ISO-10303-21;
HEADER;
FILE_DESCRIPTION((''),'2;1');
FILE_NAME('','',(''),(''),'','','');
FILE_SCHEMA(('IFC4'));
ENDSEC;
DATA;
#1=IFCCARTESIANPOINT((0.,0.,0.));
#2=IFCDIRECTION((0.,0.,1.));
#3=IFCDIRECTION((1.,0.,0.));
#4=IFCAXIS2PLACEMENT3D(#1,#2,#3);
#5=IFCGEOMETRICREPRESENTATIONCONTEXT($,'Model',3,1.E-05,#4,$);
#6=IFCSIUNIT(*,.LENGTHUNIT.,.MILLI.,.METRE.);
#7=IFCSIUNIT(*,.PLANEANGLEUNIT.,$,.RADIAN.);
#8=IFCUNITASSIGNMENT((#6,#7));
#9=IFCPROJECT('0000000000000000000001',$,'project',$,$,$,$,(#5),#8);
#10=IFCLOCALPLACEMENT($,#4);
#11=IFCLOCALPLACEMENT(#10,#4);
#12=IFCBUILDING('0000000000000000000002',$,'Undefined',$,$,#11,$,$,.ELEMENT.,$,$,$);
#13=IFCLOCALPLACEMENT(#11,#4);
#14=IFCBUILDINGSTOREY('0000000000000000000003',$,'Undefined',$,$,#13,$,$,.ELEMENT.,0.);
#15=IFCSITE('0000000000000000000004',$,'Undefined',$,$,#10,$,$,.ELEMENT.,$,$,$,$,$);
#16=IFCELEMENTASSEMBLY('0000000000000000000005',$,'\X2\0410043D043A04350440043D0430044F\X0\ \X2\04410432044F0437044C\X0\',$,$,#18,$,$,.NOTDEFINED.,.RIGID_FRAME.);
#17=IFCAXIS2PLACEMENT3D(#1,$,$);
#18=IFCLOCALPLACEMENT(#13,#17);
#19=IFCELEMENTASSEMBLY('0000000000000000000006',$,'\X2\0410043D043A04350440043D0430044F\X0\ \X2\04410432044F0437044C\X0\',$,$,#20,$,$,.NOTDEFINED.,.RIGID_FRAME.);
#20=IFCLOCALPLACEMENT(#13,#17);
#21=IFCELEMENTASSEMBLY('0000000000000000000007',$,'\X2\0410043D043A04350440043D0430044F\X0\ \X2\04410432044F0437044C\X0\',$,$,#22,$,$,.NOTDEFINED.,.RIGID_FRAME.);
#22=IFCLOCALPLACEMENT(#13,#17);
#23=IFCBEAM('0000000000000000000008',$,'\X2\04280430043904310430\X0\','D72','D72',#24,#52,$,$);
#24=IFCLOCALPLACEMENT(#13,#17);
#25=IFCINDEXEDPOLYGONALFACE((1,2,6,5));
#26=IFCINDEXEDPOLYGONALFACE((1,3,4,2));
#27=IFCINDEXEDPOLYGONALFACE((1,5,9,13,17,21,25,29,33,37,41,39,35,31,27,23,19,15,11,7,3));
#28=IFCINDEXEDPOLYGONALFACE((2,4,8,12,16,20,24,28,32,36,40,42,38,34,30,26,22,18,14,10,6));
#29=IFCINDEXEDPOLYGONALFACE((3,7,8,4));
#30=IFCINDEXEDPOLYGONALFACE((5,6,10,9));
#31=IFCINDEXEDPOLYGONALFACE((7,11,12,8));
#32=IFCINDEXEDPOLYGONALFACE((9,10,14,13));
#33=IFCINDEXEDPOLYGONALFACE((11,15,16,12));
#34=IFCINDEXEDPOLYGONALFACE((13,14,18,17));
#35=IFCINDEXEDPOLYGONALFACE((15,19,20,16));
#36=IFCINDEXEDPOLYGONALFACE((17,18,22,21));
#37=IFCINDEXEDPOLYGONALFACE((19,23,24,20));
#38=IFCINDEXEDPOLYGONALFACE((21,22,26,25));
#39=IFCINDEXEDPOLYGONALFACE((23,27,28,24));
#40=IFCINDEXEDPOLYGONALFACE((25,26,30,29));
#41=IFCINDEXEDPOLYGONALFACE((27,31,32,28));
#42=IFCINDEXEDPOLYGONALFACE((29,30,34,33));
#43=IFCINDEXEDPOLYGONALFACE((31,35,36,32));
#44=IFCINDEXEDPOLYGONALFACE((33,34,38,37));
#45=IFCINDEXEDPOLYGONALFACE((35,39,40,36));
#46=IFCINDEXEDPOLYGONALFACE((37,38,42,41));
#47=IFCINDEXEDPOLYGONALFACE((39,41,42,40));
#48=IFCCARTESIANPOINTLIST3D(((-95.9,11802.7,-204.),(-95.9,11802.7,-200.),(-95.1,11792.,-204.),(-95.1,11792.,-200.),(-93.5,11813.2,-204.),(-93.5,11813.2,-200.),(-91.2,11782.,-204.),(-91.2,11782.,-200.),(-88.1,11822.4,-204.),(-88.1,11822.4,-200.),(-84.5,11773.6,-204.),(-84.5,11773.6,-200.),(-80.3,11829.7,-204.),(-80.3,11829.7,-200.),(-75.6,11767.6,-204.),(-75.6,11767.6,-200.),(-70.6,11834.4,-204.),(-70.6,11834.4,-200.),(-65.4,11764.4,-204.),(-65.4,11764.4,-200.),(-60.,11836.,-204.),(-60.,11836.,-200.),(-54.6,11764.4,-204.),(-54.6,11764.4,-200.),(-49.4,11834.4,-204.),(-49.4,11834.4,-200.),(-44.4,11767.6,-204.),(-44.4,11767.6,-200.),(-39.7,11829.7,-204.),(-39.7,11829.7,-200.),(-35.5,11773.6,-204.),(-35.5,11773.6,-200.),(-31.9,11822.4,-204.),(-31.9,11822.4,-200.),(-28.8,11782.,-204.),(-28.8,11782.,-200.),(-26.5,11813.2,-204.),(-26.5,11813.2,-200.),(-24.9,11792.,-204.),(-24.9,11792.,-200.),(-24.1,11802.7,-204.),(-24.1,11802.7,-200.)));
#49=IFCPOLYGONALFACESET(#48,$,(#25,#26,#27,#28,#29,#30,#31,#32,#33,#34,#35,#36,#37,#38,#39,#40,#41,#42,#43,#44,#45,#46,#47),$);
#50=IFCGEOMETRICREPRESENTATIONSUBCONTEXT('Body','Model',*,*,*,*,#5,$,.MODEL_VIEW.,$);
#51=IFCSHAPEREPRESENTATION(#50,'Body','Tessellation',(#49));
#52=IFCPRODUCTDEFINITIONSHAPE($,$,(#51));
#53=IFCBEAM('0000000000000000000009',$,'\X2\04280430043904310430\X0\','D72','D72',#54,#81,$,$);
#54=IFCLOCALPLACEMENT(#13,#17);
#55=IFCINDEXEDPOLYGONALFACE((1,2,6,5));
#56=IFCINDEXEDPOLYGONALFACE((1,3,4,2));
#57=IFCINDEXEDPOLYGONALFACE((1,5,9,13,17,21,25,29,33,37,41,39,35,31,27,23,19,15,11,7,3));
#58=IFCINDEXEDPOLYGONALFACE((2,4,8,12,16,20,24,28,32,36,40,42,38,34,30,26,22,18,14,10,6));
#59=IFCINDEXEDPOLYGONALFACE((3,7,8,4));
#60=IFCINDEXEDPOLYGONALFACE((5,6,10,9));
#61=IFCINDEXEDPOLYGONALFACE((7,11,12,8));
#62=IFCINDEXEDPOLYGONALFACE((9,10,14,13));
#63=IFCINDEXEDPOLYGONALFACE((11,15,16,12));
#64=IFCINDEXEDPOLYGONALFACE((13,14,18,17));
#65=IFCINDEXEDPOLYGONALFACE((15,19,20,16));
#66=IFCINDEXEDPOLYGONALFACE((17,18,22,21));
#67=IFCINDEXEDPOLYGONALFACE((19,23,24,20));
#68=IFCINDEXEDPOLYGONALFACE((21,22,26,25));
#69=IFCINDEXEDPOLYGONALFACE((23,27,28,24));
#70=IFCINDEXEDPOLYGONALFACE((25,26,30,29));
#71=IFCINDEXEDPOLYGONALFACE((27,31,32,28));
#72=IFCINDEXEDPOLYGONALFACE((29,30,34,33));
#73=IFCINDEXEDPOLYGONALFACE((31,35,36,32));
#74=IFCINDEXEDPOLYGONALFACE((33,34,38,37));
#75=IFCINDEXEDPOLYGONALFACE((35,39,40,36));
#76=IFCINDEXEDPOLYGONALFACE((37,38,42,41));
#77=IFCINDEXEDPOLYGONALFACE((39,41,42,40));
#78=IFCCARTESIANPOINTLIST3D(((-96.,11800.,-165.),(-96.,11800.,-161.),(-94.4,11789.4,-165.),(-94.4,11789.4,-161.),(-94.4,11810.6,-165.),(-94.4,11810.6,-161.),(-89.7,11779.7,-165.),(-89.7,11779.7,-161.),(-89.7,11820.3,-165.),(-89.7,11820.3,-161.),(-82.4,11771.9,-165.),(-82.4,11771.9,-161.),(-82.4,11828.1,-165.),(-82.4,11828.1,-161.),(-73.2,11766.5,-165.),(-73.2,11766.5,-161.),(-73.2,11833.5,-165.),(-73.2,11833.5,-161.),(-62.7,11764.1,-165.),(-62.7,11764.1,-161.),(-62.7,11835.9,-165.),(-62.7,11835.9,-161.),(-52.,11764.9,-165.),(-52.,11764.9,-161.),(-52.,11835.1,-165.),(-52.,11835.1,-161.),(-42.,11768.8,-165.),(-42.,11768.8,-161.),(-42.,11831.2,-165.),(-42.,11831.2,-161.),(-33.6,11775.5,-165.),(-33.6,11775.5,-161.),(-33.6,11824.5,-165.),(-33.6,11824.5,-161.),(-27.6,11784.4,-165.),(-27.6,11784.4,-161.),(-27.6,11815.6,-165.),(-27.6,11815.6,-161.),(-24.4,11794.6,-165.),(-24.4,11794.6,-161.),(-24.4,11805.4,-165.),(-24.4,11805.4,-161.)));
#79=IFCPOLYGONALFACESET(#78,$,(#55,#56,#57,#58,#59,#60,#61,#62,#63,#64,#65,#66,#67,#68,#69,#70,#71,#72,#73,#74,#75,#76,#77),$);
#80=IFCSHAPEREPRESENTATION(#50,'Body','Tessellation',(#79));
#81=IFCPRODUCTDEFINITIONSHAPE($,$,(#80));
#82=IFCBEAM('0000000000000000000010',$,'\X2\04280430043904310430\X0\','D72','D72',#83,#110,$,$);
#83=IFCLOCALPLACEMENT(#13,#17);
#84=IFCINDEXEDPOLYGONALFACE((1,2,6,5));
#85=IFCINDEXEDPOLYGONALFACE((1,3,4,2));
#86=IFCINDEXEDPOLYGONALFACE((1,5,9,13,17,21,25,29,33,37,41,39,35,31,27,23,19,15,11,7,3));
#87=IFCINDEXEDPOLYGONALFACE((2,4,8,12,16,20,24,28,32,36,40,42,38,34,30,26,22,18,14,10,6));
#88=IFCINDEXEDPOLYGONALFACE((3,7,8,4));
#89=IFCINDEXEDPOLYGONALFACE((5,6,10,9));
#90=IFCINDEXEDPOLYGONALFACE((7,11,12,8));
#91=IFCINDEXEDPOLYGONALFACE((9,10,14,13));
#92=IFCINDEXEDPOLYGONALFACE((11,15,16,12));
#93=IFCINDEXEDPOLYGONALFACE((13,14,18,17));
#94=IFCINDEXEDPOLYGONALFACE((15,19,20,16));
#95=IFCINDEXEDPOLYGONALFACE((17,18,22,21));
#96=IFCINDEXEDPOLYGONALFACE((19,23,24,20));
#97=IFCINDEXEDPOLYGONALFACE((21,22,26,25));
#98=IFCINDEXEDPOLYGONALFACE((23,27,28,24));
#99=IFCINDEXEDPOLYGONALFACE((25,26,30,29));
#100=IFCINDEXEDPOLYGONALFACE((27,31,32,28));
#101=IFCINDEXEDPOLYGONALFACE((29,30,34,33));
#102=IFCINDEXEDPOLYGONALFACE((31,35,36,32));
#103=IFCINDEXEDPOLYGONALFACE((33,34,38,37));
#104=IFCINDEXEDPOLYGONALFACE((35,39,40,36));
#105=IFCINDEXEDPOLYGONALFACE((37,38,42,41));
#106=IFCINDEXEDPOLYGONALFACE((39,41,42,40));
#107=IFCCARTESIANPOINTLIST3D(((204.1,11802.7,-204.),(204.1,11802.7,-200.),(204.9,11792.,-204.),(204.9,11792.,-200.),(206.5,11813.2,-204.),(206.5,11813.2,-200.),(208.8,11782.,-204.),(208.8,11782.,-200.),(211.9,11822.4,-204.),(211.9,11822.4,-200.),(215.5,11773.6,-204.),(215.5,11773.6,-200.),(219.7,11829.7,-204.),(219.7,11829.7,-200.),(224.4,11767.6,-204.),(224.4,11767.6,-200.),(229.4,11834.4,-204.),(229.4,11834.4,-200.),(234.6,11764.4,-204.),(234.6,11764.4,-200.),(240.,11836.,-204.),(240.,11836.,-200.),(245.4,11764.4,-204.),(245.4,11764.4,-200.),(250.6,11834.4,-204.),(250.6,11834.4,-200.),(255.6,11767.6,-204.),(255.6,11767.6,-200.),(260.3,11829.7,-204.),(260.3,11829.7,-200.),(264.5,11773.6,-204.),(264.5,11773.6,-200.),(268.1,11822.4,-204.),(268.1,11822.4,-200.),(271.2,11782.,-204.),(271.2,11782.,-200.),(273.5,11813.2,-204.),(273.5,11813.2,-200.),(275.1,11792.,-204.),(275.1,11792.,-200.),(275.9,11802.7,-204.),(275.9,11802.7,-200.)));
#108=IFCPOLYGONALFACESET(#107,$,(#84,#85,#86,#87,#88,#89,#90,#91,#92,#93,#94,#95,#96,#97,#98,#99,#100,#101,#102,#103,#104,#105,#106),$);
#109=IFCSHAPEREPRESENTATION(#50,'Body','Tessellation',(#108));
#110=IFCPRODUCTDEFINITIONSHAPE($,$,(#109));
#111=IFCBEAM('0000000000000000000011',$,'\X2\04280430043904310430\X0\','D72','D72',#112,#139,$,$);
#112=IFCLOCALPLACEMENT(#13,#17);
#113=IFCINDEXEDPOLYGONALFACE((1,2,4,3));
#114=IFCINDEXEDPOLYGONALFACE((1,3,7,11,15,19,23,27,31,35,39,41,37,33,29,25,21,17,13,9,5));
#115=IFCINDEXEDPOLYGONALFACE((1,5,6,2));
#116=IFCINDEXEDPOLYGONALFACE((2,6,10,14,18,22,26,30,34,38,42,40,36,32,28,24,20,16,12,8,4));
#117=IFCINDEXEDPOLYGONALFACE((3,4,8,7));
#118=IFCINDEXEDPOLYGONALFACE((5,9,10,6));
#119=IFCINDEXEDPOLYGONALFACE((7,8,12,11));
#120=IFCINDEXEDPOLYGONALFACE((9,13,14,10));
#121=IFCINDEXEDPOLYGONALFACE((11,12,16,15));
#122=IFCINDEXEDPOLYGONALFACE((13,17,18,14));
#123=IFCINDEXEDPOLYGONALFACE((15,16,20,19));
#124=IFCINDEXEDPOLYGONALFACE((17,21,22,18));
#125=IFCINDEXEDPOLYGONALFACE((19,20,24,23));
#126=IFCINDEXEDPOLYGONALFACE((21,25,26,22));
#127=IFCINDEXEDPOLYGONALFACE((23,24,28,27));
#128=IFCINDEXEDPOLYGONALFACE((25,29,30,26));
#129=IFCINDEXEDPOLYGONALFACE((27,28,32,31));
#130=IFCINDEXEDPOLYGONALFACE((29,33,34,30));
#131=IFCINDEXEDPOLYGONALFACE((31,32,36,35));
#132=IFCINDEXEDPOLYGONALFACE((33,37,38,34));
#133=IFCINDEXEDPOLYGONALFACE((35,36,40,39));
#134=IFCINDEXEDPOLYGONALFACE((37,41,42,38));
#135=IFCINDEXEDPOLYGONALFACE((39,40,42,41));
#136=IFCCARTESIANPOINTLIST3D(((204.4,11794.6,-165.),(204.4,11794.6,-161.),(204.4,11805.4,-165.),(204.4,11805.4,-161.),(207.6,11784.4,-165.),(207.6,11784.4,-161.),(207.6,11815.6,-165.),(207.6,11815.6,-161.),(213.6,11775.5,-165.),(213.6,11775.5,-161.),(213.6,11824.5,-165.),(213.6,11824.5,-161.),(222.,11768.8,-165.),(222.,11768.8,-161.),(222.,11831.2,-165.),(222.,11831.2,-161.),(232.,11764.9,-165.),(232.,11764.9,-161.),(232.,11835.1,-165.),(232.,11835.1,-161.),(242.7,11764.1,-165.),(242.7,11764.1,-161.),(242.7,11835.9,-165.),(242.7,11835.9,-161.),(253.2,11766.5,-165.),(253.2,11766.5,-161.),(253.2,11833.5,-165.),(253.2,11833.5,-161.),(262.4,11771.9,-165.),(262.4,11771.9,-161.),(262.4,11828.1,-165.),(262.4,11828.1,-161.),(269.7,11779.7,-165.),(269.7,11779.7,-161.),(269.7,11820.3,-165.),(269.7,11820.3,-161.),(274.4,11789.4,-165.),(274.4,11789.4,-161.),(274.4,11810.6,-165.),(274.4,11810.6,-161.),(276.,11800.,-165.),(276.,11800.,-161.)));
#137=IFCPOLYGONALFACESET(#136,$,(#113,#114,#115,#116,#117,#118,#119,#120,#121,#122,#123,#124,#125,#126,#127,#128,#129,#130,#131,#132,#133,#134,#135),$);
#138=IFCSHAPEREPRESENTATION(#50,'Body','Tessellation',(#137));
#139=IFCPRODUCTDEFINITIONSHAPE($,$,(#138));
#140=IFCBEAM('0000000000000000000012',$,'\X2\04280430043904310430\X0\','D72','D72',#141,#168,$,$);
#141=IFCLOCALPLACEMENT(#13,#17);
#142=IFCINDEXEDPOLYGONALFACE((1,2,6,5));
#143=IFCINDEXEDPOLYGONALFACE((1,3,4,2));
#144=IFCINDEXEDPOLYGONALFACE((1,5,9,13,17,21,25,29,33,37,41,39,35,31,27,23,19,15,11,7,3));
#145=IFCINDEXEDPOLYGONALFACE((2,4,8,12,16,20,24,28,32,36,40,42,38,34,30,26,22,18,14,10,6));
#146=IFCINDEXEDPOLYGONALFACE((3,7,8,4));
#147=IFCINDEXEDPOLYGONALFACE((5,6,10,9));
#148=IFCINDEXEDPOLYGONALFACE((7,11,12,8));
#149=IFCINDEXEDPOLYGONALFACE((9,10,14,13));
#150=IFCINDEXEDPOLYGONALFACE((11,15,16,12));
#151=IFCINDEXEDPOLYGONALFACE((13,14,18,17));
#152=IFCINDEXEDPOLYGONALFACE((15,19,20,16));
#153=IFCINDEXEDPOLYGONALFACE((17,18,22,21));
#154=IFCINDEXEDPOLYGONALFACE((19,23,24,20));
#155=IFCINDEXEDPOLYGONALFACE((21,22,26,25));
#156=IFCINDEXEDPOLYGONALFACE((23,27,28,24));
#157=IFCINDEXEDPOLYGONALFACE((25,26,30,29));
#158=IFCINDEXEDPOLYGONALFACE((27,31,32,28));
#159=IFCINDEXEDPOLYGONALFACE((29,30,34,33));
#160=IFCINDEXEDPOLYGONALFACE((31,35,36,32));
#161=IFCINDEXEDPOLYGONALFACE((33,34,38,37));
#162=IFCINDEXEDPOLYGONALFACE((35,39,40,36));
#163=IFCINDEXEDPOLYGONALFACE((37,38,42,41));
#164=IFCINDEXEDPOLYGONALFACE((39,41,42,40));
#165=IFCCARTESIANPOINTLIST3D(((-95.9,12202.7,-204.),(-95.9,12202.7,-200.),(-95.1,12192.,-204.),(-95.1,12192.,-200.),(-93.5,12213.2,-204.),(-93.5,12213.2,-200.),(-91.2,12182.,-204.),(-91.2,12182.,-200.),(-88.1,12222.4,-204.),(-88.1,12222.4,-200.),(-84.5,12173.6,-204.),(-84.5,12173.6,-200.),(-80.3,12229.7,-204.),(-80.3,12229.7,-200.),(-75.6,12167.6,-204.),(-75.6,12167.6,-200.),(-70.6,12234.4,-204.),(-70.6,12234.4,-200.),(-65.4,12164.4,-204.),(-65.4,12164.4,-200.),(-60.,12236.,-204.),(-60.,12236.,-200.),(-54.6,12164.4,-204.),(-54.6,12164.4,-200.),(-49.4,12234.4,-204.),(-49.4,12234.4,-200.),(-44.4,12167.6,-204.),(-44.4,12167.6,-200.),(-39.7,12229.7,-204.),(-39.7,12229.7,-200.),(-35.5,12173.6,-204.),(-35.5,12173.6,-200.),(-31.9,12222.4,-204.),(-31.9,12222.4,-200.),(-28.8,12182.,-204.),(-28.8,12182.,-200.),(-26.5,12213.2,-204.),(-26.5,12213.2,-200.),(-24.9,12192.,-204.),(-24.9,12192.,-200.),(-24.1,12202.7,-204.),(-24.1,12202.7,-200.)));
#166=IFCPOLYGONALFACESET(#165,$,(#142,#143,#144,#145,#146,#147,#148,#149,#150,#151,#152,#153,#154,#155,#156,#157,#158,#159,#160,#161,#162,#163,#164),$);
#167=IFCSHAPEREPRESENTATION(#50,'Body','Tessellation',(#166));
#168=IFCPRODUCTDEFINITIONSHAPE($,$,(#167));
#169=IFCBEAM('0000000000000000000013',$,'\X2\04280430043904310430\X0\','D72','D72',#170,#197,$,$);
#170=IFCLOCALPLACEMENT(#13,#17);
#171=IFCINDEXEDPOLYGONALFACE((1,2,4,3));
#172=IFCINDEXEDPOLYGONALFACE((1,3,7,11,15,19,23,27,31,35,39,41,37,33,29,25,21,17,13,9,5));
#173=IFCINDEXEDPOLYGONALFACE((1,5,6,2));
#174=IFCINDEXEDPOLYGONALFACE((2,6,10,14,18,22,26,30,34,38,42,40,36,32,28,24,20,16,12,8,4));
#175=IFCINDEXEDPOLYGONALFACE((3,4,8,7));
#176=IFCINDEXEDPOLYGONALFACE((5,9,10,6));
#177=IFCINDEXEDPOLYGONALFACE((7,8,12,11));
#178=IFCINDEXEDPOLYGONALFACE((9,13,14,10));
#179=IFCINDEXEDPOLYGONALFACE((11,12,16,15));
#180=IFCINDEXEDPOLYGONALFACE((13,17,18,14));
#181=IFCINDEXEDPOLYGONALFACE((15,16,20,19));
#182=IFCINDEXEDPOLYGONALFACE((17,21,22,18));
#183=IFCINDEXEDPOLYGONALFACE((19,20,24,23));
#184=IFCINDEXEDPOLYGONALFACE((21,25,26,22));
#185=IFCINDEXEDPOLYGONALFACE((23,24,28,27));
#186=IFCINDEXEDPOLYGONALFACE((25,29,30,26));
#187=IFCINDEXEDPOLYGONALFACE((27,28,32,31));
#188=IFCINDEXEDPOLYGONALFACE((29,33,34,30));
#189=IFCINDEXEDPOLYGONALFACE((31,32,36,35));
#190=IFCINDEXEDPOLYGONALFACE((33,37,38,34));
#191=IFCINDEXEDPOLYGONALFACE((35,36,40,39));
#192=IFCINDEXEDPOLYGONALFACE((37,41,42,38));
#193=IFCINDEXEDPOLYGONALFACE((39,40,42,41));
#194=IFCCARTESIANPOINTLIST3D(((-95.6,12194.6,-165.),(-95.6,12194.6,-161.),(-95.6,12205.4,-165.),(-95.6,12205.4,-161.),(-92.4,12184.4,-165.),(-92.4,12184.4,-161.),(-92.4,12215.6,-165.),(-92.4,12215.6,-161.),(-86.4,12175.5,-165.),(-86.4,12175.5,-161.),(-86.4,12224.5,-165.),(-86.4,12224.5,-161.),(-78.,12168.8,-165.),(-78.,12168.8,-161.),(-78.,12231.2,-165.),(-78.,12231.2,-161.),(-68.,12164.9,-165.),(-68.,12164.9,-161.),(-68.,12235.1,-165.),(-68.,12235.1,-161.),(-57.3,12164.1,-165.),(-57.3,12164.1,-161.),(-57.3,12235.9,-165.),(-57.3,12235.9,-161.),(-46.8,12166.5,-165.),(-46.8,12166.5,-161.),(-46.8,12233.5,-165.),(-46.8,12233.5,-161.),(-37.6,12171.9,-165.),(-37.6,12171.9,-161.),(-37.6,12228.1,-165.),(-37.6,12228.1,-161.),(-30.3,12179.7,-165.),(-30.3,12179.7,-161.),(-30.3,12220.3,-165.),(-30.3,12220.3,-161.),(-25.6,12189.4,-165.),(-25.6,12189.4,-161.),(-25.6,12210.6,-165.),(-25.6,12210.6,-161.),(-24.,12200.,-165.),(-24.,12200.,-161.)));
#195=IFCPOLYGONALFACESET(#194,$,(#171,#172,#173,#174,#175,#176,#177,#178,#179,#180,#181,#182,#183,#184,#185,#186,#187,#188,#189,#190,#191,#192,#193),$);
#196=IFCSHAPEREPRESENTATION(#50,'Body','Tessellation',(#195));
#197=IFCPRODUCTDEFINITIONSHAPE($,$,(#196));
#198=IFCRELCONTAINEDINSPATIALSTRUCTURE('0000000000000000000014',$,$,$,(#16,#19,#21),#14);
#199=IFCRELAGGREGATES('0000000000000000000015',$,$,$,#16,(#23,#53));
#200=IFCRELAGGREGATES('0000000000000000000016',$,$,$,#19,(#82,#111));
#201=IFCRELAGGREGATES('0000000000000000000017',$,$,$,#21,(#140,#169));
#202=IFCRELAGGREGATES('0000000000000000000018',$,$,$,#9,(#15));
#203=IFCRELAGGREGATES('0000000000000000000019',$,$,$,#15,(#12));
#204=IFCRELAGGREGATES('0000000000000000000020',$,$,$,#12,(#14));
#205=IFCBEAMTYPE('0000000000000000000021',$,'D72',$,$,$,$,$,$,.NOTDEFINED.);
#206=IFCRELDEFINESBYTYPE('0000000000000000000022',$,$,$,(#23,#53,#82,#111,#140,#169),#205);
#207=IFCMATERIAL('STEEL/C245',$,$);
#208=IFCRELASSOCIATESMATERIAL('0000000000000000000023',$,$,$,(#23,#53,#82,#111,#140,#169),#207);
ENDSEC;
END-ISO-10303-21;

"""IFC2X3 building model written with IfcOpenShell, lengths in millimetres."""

from ifc_helpers import new_model, si_unit, frame, origin_with_axes, origin_2d_with_axis, place, context, subcontext, project, spatial, circle, extrude, material, type_object, element, aggregate, save


model = new_model("IFC2X3")

# Units and contexts
model_context = context("Model", 3, precision=1e-05, world=origin_with_axes())
body_context = subcontext(model_context, "Body", "Model", "MODEL_VIEW")
ifc_project = project(units=[si_unit("LENGTHUNIT", "METRE", prefix="MILLI"), si_unit("PLANEANGLEUNIT", "RADIAN")], contexts=[model_context])

# Site, building, storey
site_placement = place(None, origin_with_axes())
site = spatial("IfcSite", under=ifc_project, at=site_placement, Name="Undefined", CompositionType="ELEMENT")
building_placement = place(site_placement, origin_with_axes())
building = spatial("IfcBuilding", under=site, at=building_placement, Name="Undefined", CompositionType="ELEMENT")
storey_placement = place(building_placement, origin_with_axes())
storey = spatial("IfcBuildingStorey", under=building, at=storey_placement, Name="Undefined", CompositionType="ELEMENT", Elevation=0.0)

# Shared definitions
ifc_material_1 = material(Name="STEEL/C245")

# Element assemblies
assembly_1_placement = place(storey_placement, origin_with_axes())
assembly_1 = element("IfcElementAssembly", 1, at=assembly_1_placement, inside=storey, Name="Анкерная связь", AssemblyPlace="NOTDEFINED", PredefinedType="RIGID_FRAME")
assembly_2_placement = place(storey_placement, origin_with_axes())
assembly_2 = element("IfcElementAssembly", 2, at=assembly_2_placement, inside=storey, Name="Анкерная связь", AssemblyPlace="NOTDEFINED", PredefinedType="RIGID_FRAME")
assembly_3_placement = place(storey_placement, origin_with_axes())
assembly_3 = element("IfcElementAssembly", 3, at=assembly_3_placement, inside=storey, Name="Анкерная связь", AssemblyPlace="NOTDEFINED", PredefinedType="RIGID_FRAME")

# Beams
beam_type_1 = type_object("IfcBeamType", Name="D72", PredefinedType="NOTDEFINED")
beam_1_placement = place(assembly_1_placement, frame((-60.0, 11800.0, -200.0), z_axis=(-1.0, 0.0, 0.0), x_axis=(0.0, 0.0, -1.0)))
beam_1 = element("IfcBeam", 4, at=beam_1_placement, type_object=beam_type_1, material=ifc_material_1, Name="Шайба", Description="D72", ObjectType="D72", context=body_context, shape_type="SweptSolid", body=[
    extrude(circle(Radius=36.0, at=origin_2d_with_axis()), frame((4.0, 0.0, 0.0), z_axis=(-1.0, 0.0, 0.0), x_axis=(0.0, -1.0, 0.0)), (0.0, 0.0, 1.0), 4.0),
])
beam_2_placement = place(assembly_1_placement, frame((-60.0, 11800.0, -161.0), z_axis=(0.0, -1.0, 0.0), x_axis=(0.0, 0.0, -1.0)))
beam_2 = element("IfcBeam", 5, at=beam_2_placement, type_object=beam_type_1, material=ifc_material_1, Name="Шайба", Description="D72", ObjectType="D72", context=body_context, shape_type="SweptSolid", body=[
    extrude(circle(Radius=36.0, at=origin_2d_with_axis()), frame((4.0, 0.0, 0.0), z_axis=(-1.0, 0.0, 0.0), x_axis=(0.0, -1.0, 0.0)), (0.0, 0.0, 1.0), 4.0),
])
beam_3_placement = place(assembly_2_placement, frame((240.0, 11800.0, -200.0), z_axis=(-1.0, 0.0, 0.0), x_axis=(0.0, 0.0, -1.0)))
beam_3 = element("IfcBeam", 6, at=beam_3_placement, type_object=beam_type_1, material=ifc_material_1, Name="Шайба", Description="D72", ObjectType="D72", context=body_context, shape_type="SweptSolid", body=[
    extrude(circle(Radius=36.0, at=origin_2d_with_axis()), frame((4.0, 0.0, 0.0), z_axis=(-1.0, 0.0, 0.0), x_axis=(0.0, -1.0, 0.0)), (0.0, 0.0, 1.0), 4.0),
])
beam_4_placement = place(assembly_2_placement, frame((240.0, 11800.0, -161.0), z_axis=(0.0, 1.0, 0.0), x_axis=(0.0, 0.0, -1.0)))
beam_4 = element("IfcBeam", 7, at=beam_4_placement, type_object=beam_type_1, material=ifc_material_1, Name="Шайба", Description="D72", ObjectType="D72", context=body_context, shape_type="SweptSolid", body=[
    extrude(circle(Radius=36.0, at=origin_2d_with_axis()), frame((4.0, 0.0, 0.0), z_axis=(-1.0, 0.0, 0.0), x_axis=(0.0, -1.0, 0.0)), (0.0, 0.0, 1.0), 4.0),
])
beam_5_placement = place(assembly_3_placement, frame((-60.0, 12200.0, -200.0), z_axis=(-1.0, 0.0, 0.0), x_axis=(0.0, 0.0, -1.0)))
beam_5 = element("IfcBeam", 8, at=beam_5_placement, type_object=beam_type_1, material=ifc_material_1, Name="Шайба", Description="D72", ObjectType="D72", context=body_context, shape_type="SweptSolid", body=[
    extrude(circle(Radius=36.0, at=origin_2d_with_axis()), frame((4.0, 0.0, 0.0), z_axis=(-1.0, 0.0, 0.0), x_axis=(0.0, -1.0, 0.0)), (0.0, 0.0, 1.0), 4.0),
])
beam_6_placement = place(assembly_3_placement, frame((-60.0, 12200.0, -161.0), z_axis=(0.0, 1.0, 0.0), x_axis=(0.0, 0.0, -1.0)))
beam_6 = element("IfcBeam", 9, at=beam_6_placement, type_object=beam_type_1, material=ifc_material_1, Name="Шайба", Description="D72", ObjectType="D72", context=body_context, shape_type="SweptSolid", body=[
    extrude(circle(Radius=36.0, at=origin_2d_with_axis()), frame((4.0, 0.0, 0.0), z_axis=(-1.0, 0.0, 0.0), x_axis=(0.0, -1.0, 0.0)), (0.0, 0.0, 1.0), 4.0),
])

aggregate(assembly_1, [beam_1, beam_2])
aggregate(assembly_2, [beam_3, beam_4])
aggregate(assembly_3, [beam_5, beam_6])

save(model, "model.ifc")
